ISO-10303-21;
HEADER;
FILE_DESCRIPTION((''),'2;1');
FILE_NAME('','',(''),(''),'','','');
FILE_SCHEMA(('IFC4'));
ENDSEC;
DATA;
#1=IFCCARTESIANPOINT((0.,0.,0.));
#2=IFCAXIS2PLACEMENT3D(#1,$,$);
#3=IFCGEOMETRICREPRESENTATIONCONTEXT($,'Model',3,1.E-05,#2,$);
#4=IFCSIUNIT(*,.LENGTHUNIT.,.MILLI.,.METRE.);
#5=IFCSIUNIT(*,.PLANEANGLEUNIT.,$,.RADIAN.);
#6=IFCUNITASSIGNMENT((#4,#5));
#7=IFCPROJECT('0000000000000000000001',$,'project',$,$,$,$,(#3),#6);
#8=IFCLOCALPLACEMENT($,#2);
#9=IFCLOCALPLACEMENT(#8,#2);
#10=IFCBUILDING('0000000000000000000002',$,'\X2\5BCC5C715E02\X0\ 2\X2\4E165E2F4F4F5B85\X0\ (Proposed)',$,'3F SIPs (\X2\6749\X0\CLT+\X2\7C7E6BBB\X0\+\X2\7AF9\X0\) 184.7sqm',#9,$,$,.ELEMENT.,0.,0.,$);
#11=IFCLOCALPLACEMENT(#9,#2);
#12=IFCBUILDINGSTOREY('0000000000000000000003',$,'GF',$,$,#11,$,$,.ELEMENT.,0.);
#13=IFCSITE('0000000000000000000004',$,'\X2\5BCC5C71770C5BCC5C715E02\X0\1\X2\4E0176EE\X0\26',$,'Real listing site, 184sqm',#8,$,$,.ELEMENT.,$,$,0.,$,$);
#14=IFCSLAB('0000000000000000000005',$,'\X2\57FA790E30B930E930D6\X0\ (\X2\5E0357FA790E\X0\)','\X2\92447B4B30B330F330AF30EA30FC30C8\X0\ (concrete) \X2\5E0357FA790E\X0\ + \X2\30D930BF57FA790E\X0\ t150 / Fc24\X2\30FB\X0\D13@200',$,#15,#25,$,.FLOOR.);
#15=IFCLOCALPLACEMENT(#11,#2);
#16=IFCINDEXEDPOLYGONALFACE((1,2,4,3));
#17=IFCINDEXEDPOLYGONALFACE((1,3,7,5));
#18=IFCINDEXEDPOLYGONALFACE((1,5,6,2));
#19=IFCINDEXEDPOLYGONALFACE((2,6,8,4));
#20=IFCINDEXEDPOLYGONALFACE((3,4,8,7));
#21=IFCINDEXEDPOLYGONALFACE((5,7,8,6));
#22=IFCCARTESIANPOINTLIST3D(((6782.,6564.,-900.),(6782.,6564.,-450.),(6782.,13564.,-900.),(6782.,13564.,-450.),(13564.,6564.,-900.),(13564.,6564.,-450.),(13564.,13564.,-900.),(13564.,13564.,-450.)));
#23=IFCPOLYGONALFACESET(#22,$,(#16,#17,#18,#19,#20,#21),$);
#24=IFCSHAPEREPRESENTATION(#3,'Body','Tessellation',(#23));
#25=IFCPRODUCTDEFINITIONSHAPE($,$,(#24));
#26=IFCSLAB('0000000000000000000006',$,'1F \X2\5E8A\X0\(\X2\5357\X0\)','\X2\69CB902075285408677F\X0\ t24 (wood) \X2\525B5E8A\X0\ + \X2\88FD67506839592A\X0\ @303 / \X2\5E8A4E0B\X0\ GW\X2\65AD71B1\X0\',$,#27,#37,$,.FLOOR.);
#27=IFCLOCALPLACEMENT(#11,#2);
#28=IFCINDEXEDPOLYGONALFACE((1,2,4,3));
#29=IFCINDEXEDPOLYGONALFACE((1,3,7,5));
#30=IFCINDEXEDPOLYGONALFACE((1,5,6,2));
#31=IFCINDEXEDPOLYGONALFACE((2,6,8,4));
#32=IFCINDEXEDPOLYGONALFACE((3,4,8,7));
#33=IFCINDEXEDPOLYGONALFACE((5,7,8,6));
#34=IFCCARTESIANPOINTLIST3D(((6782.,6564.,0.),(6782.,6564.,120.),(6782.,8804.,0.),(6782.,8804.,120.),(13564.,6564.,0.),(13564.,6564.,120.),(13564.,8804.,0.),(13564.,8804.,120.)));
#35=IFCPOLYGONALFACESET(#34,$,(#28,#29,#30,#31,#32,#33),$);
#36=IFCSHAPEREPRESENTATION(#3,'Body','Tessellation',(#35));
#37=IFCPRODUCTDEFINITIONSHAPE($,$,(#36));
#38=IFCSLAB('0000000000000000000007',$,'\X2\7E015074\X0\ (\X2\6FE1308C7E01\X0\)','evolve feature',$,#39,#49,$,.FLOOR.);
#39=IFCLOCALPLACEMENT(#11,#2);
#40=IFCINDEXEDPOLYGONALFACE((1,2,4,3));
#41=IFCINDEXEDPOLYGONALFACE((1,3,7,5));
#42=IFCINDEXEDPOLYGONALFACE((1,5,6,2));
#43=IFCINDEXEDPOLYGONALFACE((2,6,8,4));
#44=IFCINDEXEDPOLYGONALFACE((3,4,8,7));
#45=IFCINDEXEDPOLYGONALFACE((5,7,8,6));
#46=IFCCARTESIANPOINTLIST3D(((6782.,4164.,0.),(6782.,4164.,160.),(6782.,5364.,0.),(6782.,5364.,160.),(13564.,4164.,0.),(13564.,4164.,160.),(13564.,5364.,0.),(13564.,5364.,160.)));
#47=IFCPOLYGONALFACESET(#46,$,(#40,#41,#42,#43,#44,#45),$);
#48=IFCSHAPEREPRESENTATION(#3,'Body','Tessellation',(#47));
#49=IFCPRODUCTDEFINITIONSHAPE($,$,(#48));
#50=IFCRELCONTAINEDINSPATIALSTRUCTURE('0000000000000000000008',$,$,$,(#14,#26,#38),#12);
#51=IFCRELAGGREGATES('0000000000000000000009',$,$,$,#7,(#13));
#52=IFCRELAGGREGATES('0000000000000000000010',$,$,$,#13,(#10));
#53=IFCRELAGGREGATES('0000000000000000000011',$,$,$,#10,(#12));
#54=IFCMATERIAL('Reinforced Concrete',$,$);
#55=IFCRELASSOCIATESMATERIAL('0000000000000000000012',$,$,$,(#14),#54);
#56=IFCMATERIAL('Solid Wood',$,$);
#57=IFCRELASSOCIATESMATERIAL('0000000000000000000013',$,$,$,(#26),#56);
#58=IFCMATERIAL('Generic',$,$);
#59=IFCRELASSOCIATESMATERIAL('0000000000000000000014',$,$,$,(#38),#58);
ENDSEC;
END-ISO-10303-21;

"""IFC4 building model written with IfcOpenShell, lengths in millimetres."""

from ifc_helpers import new_model, si_unit, frame, frame_2d, origin, place, context, project, spatial, rectangle, extrude, material, element, save


model = new_model("IFC4")

# Units and contexts
model_context = context("Model", 3, precision=1e-05, world=origin())
ifc_project = project(units=[si_unit("LENGTHUNIT", "METRE", prefix="MILLI"), si_unit("PLANEANGLEUNIT", "RADIAN")], contexts=[model_context])

# Site, building, storey
site_placement = place(None, origin())
site = spatial("IfcSite", under=ifc_project, at=site_placement, Name="富山県富山市1丁目26", ObjectType="Real listing site, 184sqm", CompositionType="ELEMENT", RefElevation=0.0)
building_placement = place(site_placement, origin())
building = spatial("IfcBuilding", under=site, at=building_placement, Name="富山市 2世帯住宅 (Proposed)", ObjectType="3F SIPs (杉CLT+籾殻+竹) 184.7sqm", CompositionType="ELEMENT", ElevationOfRefHeight=0.0, ElevationOfTerrain=0.0)
storey_placement = place(building_placement, origin())
storey = spatial("IfcBuildingStorey", under=building, at=storey_placement, Name="GF", CompositionType="ELEMENT", Elevation=0.0)

# Slabs
ifc_material_1 = material(Name="Reinforced Concrete")
slab_1_placement = place(storey_placement, frame((3391.0, 3282.0, -450.0)))
element("IfcSlab", 1, at=slab_1_placement, inside=storey, material=ifc_material_1, Name="基礎スラブ (布基礎)", Description="鉄筋コンクリート (concrete) 布基礎 + ベタ基礎 t150 / Fc24・D13@200", PredefinedType="FLOOR", context=model_context, shape_type="SweptSolid", body=[
    extrude(rectangle(XDim=6782.0, YDim=7000.0, at=frame_2d((3391.0, 3500.0))), frame((3391.0, 3282.0, -450.0)), (0.0, 0.0, 1.0), 450.0),
])
ifc_material_2 = material(Name="Solid Wood")
slab_2_placement = place(storey_placement, frame((3391.0, 3282.0, 0.0)))
element("IfcSlab", 2, at=slab_2_placement, inside=storey, material=ifc_material_2, Name="1F 床(南)", Description="構造用合板 t24 (wood) 剛床 + 製材根太 @303 / 床下 GW断熱", PredefinedType="FLOOR", context=model_context, shape_type="SweptSolid", body=[
    extrude(rectangle(XDim=6782.0, YDim=2240.0, at=frame_2d((3391.0, 1120.0))), frame((3391.0, 3282.0, 0.0)), (0.0, 0.0, 1.0), 120.0),
])
ifc_material_3 = material(Name="Generic")
slab_3_placement = place(storey_placement, frame((3391.0, 2082.0, 0.0)))
element("IfcSlab", 3, at=slab_3_placement, inside=storey, material=ifc_material_3, Name="縁側 (濡れ縁)", Description="evolve feature", PredefinedType="FLOOR", context=model_context, shape_type="SweptSolid", body=[
    extrude(rectangle(XDim=6782.0, YDim=1200.0, at=frame_2d((3391.0, 600.0))), frame((3391.0, 2082.0, 0.0)), (0.0, 0.0, 1.0), 160.0),
])

save(model, "model.ifc")
